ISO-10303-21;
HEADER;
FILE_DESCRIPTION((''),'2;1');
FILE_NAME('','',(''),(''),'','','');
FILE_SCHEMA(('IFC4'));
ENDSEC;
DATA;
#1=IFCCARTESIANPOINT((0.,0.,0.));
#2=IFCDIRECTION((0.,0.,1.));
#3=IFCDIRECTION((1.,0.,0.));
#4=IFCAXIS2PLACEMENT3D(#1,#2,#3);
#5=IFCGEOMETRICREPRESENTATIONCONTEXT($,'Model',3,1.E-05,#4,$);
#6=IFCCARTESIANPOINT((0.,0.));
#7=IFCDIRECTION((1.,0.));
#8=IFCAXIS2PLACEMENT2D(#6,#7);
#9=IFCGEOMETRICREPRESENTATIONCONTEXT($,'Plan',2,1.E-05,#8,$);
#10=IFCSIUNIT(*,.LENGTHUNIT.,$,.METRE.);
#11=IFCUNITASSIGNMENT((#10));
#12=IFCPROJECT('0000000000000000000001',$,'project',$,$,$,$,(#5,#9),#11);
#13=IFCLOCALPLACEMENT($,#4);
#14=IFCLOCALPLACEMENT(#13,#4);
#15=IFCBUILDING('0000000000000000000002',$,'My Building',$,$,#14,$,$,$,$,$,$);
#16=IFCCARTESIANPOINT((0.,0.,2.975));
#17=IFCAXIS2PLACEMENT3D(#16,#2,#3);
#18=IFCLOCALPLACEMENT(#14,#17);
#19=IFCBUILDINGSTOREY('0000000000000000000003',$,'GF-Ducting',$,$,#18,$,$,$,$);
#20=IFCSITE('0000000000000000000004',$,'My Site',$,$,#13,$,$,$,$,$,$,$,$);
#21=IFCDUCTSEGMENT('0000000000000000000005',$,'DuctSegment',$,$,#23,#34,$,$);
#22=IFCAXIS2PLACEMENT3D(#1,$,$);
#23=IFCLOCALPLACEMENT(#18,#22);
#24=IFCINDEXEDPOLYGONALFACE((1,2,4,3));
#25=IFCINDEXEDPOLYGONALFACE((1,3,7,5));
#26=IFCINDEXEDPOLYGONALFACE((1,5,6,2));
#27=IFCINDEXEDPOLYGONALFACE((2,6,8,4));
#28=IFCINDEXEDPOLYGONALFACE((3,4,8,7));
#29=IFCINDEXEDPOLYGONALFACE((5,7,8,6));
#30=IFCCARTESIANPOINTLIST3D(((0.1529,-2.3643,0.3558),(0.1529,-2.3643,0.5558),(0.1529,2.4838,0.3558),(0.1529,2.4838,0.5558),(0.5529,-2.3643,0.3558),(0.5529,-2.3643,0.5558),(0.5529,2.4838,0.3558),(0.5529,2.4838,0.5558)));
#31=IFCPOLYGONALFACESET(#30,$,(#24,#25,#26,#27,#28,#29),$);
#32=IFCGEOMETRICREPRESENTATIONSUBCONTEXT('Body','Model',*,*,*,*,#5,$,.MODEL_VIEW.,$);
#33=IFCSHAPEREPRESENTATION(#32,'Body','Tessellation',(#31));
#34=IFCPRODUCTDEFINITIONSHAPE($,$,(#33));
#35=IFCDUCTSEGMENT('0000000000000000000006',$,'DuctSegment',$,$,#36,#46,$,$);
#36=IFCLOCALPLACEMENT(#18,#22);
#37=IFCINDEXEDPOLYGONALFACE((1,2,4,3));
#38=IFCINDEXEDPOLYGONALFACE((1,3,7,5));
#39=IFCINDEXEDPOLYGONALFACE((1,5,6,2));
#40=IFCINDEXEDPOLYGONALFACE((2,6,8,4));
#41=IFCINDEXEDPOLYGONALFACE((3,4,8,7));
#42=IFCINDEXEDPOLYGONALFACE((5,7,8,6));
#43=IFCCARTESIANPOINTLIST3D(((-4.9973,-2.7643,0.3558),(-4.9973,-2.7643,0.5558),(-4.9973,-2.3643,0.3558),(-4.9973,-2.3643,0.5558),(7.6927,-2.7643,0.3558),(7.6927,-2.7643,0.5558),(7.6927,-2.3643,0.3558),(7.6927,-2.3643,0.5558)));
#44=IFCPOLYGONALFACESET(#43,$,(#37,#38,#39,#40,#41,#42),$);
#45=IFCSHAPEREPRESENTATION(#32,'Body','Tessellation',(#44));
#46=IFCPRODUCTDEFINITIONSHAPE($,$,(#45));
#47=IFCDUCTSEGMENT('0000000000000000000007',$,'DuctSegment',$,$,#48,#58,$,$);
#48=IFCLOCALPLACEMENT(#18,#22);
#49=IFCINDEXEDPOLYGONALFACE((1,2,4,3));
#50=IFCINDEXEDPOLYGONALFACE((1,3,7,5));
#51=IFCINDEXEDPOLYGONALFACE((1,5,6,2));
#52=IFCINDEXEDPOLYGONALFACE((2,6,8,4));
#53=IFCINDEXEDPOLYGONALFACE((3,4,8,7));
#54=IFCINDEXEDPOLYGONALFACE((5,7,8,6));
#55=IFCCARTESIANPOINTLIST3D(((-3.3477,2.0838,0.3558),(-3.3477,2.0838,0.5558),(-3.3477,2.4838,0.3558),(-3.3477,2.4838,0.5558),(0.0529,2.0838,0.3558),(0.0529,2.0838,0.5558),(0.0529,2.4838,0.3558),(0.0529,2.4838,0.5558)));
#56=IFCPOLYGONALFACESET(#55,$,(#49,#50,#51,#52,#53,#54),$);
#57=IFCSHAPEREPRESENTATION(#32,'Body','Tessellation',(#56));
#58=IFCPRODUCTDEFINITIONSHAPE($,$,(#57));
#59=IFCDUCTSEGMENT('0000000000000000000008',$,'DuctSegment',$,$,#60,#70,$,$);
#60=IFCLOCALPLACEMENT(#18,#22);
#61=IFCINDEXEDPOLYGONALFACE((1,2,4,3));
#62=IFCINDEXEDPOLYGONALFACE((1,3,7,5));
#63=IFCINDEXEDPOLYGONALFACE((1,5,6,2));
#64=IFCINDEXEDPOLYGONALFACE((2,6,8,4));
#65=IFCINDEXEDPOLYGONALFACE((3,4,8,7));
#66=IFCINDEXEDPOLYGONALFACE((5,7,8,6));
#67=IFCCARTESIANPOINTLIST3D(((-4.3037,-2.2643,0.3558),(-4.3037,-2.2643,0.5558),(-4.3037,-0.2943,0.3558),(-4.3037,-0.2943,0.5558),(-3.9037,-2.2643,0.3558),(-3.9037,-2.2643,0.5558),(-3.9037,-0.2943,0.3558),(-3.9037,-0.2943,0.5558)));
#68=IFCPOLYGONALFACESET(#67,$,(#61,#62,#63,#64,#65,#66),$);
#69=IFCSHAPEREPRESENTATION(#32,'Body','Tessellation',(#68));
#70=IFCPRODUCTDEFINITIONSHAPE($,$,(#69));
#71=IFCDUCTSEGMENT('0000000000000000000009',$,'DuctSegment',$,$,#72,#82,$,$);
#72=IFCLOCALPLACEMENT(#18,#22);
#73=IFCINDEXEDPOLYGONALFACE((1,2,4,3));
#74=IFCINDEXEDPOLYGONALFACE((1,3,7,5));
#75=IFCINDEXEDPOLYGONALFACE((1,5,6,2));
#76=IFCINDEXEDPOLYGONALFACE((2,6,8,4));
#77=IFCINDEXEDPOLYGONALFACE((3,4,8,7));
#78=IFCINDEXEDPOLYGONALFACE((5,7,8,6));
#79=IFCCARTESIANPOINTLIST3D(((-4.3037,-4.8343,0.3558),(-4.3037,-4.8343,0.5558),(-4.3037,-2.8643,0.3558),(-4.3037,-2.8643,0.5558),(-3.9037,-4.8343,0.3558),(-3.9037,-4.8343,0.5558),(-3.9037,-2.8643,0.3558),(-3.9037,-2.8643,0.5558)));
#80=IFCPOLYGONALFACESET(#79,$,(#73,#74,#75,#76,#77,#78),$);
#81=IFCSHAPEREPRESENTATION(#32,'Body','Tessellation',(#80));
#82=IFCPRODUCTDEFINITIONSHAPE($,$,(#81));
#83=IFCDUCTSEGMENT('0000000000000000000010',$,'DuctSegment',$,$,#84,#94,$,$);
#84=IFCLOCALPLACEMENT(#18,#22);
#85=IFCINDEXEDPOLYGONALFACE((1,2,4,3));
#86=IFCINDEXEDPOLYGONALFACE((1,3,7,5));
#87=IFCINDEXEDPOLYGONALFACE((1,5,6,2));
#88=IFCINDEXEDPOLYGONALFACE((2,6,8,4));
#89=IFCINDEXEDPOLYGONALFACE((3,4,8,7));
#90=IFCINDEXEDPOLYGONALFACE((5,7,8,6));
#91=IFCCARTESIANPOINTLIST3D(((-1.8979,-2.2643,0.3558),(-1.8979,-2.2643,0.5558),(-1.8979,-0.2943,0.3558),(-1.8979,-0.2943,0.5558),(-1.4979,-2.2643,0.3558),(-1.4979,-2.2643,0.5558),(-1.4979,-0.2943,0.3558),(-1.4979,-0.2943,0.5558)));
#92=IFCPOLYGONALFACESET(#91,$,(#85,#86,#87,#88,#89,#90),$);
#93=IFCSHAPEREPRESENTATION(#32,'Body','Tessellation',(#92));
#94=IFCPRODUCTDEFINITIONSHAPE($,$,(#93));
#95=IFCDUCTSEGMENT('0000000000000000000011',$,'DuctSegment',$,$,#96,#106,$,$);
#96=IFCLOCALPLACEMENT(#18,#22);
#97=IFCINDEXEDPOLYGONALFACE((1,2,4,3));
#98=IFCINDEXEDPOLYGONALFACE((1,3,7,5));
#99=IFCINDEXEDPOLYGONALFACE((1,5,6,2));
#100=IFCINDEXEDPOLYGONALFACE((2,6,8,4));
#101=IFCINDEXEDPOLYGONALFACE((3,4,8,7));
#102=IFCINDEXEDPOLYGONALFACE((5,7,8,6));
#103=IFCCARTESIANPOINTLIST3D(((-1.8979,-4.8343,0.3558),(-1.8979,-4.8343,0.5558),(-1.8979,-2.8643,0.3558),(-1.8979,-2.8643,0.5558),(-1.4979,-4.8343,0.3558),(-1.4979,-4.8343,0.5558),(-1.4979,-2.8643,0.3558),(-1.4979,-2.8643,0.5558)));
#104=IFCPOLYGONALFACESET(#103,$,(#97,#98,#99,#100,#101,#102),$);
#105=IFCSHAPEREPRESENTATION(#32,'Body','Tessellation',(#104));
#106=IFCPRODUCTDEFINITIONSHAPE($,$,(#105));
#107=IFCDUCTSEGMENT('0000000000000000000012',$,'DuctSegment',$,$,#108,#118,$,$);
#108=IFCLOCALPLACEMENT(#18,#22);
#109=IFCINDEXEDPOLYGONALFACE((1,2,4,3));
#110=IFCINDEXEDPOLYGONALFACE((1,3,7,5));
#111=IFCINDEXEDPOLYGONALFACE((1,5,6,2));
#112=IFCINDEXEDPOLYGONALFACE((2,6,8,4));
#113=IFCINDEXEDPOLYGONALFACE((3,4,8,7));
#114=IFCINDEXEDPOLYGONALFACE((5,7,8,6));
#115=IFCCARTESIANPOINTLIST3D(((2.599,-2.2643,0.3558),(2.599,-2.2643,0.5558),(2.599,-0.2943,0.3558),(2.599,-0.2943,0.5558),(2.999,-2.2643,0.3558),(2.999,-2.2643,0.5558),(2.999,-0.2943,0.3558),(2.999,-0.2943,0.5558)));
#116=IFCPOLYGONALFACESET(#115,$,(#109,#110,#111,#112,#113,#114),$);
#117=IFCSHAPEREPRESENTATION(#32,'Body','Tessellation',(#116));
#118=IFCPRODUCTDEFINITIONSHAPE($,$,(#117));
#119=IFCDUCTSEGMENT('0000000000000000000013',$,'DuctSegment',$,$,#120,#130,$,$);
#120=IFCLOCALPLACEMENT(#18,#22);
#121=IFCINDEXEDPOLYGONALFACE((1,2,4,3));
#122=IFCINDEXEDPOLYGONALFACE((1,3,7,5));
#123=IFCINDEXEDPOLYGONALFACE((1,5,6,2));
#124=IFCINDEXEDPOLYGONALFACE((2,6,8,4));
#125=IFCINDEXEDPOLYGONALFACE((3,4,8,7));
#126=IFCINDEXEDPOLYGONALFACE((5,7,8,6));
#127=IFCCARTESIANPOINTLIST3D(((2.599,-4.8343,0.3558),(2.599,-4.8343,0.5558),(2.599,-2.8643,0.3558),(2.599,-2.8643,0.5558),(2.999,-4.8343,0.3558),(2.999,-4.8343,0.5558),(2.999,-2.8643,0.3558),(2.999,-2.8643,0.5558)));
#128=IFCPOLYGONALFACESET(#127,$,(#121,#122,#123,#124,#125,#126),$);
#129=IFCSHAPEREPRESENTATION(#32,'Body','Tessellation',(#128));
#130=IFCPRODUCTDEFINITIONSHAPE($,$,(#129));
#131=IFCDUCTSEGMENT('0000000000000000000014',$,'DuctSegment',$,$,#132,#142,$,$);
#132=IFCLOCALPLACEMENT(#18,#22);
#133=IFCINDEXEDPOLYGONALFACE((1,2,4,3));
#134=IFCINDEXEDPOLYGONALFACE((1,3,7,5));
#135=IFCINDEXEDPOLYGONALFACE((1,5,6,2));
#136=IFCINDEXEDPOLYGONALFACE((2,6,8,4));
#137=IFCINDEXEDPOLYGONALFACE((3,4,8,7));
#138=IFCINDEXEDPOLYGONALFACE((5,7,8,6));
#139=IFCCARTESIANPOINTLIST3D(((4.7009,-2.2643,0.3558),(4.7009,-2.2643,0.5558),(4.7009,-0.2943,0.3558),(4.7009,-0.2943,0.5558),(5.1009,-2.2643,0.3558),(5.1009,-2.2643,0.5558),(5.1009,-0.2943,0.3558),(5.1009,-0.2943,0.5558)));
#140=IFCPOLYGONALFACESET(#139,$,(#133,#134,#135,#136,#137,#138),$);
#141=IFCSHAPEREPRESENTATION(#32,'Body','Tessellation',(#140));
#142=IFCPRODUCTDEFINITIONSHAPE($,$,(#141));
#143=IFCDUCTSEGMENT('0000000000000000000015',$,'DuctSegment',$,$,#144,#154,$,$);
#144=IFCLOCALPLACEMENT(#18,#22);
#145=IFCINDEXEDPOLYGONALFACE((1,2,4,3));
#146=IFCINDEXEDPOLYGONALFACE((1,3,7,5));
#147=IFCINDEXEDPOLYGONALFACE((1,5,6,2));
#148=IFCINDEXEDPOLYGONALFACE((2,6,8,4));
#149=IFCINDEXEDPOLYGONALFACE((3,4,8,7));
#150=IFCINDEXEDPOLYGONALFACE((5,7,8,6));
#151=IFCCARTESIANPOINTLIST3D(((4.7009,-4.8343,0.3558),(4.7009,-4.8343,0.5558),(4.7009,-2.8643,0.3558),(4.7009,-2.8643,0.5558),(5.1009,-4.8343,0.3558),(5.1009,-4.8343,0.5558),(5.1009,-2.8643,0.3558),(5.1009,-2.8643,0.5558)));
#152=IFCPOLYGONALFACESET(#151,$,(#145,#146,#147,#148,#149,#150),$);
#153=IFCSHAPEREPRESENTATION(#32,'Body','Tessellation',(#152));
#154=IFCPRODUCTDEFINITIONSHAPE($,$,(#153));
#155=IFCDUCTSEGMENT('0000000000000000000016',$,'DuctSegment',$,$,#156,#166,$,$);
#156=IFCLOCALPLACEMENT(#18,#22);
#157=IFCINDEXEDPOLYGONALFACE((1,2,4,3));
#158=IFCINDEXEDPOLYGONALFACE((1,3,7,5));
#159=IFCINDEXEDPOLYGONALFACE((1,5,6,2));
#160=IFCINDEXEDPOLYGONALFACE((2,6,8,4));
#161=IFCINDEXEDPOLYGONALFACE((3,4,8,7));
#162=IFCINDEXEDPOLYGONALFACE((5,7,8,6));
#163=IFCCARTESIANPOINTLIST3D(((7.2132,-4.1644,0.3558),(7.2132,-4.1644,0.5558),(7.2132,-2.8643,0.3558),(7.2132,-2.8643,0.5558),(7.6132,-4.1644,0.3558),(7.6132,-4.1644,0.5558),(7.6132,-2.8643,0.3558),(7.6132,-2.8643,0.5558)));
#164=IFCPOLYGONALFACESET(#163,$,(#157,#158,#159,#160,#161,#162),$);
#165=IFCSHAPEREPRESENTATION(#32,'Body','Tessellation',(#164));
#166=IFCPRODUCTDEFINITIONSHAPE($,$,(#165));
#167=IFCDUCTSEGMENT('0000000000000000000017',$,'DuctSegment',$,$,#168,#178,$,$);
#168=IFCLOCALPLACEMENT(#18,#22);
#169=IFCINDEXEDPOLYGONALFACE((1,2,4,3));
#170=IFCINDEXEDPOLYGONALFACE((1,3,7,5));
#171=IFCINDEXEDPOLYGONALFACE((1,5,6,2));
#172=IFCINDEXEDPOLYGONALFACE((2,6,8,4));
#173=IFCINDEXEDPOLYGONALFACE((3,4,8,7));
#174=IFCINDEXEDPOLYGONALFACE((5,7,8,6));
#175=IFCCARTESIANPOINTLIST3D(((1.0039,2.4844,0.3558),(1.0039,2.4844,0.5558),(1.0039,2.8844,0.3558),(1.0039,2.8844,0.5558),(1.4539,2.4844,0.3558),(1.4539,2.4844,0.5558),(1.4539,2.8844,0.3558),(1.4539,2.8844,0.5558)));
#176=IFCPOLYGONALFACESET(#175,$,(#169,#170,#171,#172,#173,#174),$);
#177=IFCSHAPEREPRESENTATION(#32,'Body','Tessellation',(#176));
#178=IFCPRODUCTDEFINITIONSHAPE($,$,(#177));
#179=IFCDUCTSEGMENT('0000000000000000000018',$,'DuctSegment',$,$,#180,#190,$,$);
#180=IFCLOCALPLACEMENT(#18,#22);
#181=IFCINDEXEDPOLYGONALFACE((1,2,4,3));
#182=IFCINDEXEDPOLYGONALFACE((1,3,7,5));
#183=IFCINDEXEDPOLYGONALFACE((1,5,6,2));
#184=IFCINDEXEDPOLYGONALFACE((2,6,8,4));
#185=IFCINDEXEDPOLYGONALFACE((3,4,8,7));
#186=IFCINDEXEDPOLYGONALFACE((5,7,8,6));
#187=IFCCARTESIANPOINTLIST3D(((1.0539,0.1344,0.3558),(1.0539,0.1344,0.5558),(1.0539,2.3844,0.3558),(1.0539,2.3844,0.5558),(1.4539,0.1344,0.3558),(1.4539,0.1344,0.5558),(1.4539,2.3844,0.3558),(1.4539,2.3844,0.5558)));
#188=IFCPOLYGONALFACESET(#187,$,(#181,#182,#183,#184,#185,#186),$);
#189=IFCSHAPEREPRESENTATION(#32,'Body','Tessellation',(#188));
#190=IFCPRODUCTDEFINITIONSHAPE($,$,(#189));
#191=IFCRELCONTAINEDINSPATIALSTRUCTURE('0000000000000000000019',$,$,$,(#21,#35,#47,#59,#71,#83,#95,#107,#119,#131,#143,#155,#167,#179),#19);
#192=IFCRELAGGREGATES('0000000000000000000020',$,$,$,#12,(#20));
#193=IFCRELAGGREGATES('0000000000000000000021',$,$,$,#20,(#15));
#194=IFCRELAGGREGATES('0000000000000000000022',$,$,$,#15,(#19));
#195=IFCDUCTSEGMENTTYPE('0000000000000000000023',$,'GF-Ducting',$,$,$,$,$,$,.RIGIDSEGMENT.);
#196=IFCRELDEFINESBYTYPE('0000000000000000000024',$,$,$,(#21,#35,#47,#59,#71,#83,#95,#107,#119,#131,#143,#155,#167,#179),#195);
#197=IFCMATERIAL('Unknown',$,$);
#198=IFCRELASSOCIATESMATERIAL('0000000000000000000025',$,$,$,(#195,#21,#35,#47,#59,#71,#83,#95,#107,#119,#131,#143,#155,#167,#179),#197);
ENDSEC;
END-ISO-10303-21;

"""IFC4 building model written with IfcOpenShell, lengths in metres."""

from ifc_helpers import new_model, si_unit, frame, origin_with_axes, origin_2d_with_axis, place, context, subcontext, project, spatial, rectangle, extrude, material, material_profile, profile_set, profile_usage, type_object, element, save


model = new_model("IFC4")

# Units and contexts
model_context = context("Model", 3, precision=1e-05, world=origin_with_axes())
plan_context = context("Plan", 2, precision=1e-05, world=origin_2d_with_axis())
body_context = subcontext(model_context, "Body", "Model", "MODEL_VIEW")
ifc_project = project(units=[si_unit("LENGTHUNIT", "METRE")], contexts=[model_context, plan_context])

# Site, building, storey
site_placement = place(None, origin_with_axes())
site = spatial("IfcSite", under=ifc_project, at=site_placement, Name="My Site")
building_placement = place(site_placement, origin_with_axes())
building = spatial("IfcBuilding", under=site, at=building_placement, Name="My Building")
storey_placement = place(building_placement, frame((0.0, 0.0, 2.975), z_axis=(0.0, 0.0, 1.0), x_axis=(1.0, 0.0, 0.0)))
storey = spatial("IfcBuildingStorey", under=building, at=storey_placement, Name="GF-Ducting")

# Duct segments
ifc_material = material(Name="Unknown")
ifc_material_profile_1 = material_profile(ifc_material, rectangle(XDim=0.4, YDim=0.2))
ifc_profile_set_1 = profile_set([ifc_material_profile_1])
ifc_profile_usage_1 = profile_usage(ifc_profile_set_1, cardinal=5)
duct_segment_type = type_object("IfcDuctSegmentType", Name="GF-Ducting", PredefinedType="RIGIDSEGMENT", material=ifc_profile_set_1)
duct_segment_1_placement = place(storey_placement, frame((0.3529, 2.4838, 0.4558), z_axis=(0.0, -1.0, 0.0), x_axis=(1.0, 0.0, 0.0)))
element("IfcDuctSegment", 1, at=duct_segment_1_placement, inside=storey, type_object=duct_segment_type, material=ifc_profile_usage_1, Name="DuctSegment", context=body_context, shape_type="SweptSolid", body=[
    extrude(rectangle(XDim=0.4, YDim=0.2), origin_with_axes(), (0.0, 0.0, 1.0), 4.8481),
])
ifc_profile_usage_2 = profile_usage(ifc_profile_set_1, cardinal=5)
duct_segment_2_placement = place(storey_placement, frame((-4.9973, -2.5643, 0.4558), z_axis=(1.0, -0.000001, 0.000001), x_axis=(0.000001, 1.0, 0.0)))
element("IfcDuctSegment", 2, at=duct_segment_2_placement, inside=storey, type_object=duct_segment_type, material=ifc_profile_usage_2, Name="DuctSegment", context=body_context, shape_type="SweptSolid", body=[
    extrude(rectangle(XDim=0.4, YDim=0.2), origin_with_axes(), (0.0, 0.0, 1.0), 12.69),
])
ifc_profile_usage_3 = profile_usage(ifc_profile_set_1, cardinal=5)
duct_segment_3_placement = place(storey_placement, frame((-3.3477, 2.2838, 0.4558), z_axis=(1.0, 0.0, 0.0), x_axis=(0.0, 1.0, 0.0)))
element("IfcDuctSegment", 3, at=duct_segment_3_placement, inside=storey, type_object=duct_segment_type, material=ifc_profile_usage_3, Name="DuctSegment", context=body_context, shape_type="SweptSolid", body=[
    extrude(rectangle(XDim=0.4, YDim=0.2), origin_with_axes(), (0.0, 0.0, 1.0), 3.4007),
])
ifc_profile_usage_4 = profile_usage(ifc_profile_set_1, cardinal=5)
duct_segment_4_placement = place(storey_placement, frame((-4.1037, -2.2643, 0.4558), z_axis=(0.0, 1.0, 0.0), x_axis=(-1.0, 0.0, 0.0)))
element("IfcDuctSegment", 4, at=duct_segment_4_placement, inside=storey, type_object=duct_segment_type, material=ifc_profile_usage_4, Name="DuctSegment", context=body_context, shape_type="SweptSolid", body=[
    extrude(rectangle(XDim=0.4, YDim=0.2), origin_with_axes(), (0.0, 0.0, 1.0), 1.97),
])
ifc_profile_usage_5 = profile_usage(ifc_profile_set_1, cardinal=5)
duct_segment_5_placement = place(storey_placement, frame((-4.1037, -4.8343, 0.4558), z_axis=(0.0, 1.0, 0.0), x_axis=(-1.0, 0.0, 0.0)))
element("IfcDuctSegment", 5, at=duct_segment_5_placement, inside=storey, type_object=duct_segment_type, material=ifc_profile_usage_5, Name="DuctSegment", context=body_context, shape_type="SweptSolid", body=[
    extrude(rectangle(XDim=0.4, YDim=0.2), origin_with_axes(), (0.0, 0.0, 1.0), 1.97),
])
ifc_profile_usage_6 = profile_usage(ifc_profile_set_1, cardinal=5)
duct_segment_6_placement = place(storey_placement, frame((-1.6979, -2.2643, 0.4558), z_axis=(0.0, 1.0, 0.0), x_axis=(-1.0, 0.0, 0.0)))
element("IfcDuctSegment", 6, at=duct_segment_6_placement, inside=storey, type_object=duct_segment_type, material=ifc_profile_usage_6, Name="DuctSegment", context=body_context, shape_type="SweptSolid", body=[
    extrude(rectangle(XDim=0.4, YDim=0.2), origin_with_axes(), (0.0, 0.0, 1.0), 1.97),
])
ifc_profile_usage_7 = profile_usage(ifc_profile_set_1, cardinal=5)
duct_segment_7_placement = place(storey_placement, frame((-1.6979, -4.8343, 0.4558), z_axis=(0.0, 1.0, 0.0), x_axis=(-1.0, 0.0, 0.0)))
element("IfcDuctSegment", 7, at=duct_segment_7_placement, inside=storey, type_object=duct_segment_type, material=ifc_profile_usage_7, Name="DuctSegment", context=body_context, shape_type="SweptSolid", body=[
    extrude(rectangle(XDim=0.4, YDim=0.2), origin_with_axes(), (0.0, 0.0, 1.0), 1.97),
])
ifc_profile_usage_8 = profile_usage(ifc_profile_set_1, cardinal=5)
duct_segment_8_placement = place(storey_placement, frame((2.799, -2.2643, 0.4558), z_axis=(0.0, 1.0, 0.0), x_axis=(-1.0, 0.0, 0.0)))
element("IfcDuctSegment", 8, at=duct_segment_8_placement, inside=storey, type_object=duct_segment_type, material=ifc_profile_usage_8, Name="DuctSegment", context=body_context, shape_type="SweptSolid", body=[
    extrude(rectangle(XDim=0.4, YDim=0.2), origin_with_axes(), (0.0, 0.0, 1.0), 1.97),
])
ifc_profile_usage_9 = profile_usage(ifc_profile_set_1, cardinal=5)
duct_segment_9_placement = place(storey_placement, frame((2.799, -4.8343, 0.4558), z_axis=(0.0, 1.0, 0.0), x_axis=(-1.0, 0.0, 0.0)))
element("IfcDuctSegment", 9, at=duct_segment_9_placement, inside=storey, type_object=duct_segment_type, material=ifc_profile_usage_9, Name="DuctSegment", context=body_context, shape_type="SweptSolid", body=[
    extrude(rectangle(XDim=0.4, YDim=0.2), origin_with_axes(), (0.0, 0.0, 1.0), 1.97),
])
ifc_profile_usage_10 = profile_usage(ifc_profile_set_1, cardinal=5)
duct_segment_10_placement = place(storey_placement, frame((4.9009, -2.2643, 0.4558), z_axis=(0.0, 1.0, 0.0), x_axis=(-1.0, 0.0, 0.0)))
element("IfcDuctSegment", 10, at=duct_segment_10_placement, inside=storey, type_object=duct_segment_type, material=ifc_profile_usage_10, Name="DuctSegment", context=body_context, shape_type="SweptSolid", body=[
    extrude(rectangle(XDim=0.4, YDim=0.2), origin_with_axes(), (0.0, 0.0, 1.0), 1.97),
])
ifc_profile_usage_11 = profile_usage(ifc_profile_set_1, cardinal=5)
duct_segment_11_placement = place(storey_placement, frame((4.9009, -4.8343, 0.4558), z_axis=(0.0, 1.0, 0.0), x_axis=(-1.0, 0.0, 0.0)))
element("IfcDuctSegment", 11, at=duct_segment_11_placement, inside=storey, type_object=duct_segment_type, material=ifc_profile_usage_11, Name="DuctSegment", context=body_context, shape_type="SweptSolid", body=[
    extrude(rectangle(XDim=0.4, YDim=0.2), origin_with_axes(), (0.0, 0.0, 1.0), 1.97),
])
ifc_profile_usage_12 = profile_usage(ifc_profile_set_1, cardinal=5)
duct_segment_12_placement = place(storey_placement, frame((7.4132, -4.1644, 0.4558), z_axis=(0.0, 1.0, 0.0), x_axis=(-1.0, 0.0, 0.0)))
element("IfcDuctSegment", 12, at=duct_segment_12_placement, inside=storey, type_object=duct_segment_type, material=ifc_profile_usage_12, Name="DuctSegment", context=body_context, shape_type="SweptSolid", body=[
    extrude(rectangle(XDim=0.4, YDim=0.2), origin_with_axes(), (0.0, 0.0, 1.0), 1.3001),
])
ifc_profile_usage_13 = profile_usage(ifc_profile_set_1, cardinal=5)
duct_segment_13_placement = place(storey_placement, frame((1.0039, 2.6844, 0.4558), z_axis=(1.0, 0.0, 0.0), x_axis=(0.0, 1.0, 0.0)))
element("IfcDuctSegment", 13, at=duct_segment_13_placement, inside=storey, type_object=duct_segment_type, material=ifc_profile_usage_13, Name="DuctSegment", context=body_context, shape_type="SweptSolid", body=[
    extrude(rectangle(XDim=0.4, YDim=0.2), origin_with_axes(), (0.0, 0.0, 1.0), 0.45),
])
ifc_profile_usage_14 = profile_usage(ifc_profile_set_1, cardinal=5)
duct_segment_14_placement = place(storey_placement, frame((1.2539, 2.3844, 0.4558), z_axis=(0.0, -1.0, 0.0), x_axis=(1.0, 0.0, 0.0)))
element("IfcDuctSegment", 14, at=duct_segment_14_placement, inside=storey, type_object=duct_segment_type, material=ifc_profile_usage_14, Name="DuctSegment", context=body_context, shape_type="SweptSolid", body=[
    extrude(rectangle(XDim=0.4, YDim=0.2), origin_with_axes(), (0.0, 0.0, 1.0), 2.25),
])

save(model, "model.ifc")
